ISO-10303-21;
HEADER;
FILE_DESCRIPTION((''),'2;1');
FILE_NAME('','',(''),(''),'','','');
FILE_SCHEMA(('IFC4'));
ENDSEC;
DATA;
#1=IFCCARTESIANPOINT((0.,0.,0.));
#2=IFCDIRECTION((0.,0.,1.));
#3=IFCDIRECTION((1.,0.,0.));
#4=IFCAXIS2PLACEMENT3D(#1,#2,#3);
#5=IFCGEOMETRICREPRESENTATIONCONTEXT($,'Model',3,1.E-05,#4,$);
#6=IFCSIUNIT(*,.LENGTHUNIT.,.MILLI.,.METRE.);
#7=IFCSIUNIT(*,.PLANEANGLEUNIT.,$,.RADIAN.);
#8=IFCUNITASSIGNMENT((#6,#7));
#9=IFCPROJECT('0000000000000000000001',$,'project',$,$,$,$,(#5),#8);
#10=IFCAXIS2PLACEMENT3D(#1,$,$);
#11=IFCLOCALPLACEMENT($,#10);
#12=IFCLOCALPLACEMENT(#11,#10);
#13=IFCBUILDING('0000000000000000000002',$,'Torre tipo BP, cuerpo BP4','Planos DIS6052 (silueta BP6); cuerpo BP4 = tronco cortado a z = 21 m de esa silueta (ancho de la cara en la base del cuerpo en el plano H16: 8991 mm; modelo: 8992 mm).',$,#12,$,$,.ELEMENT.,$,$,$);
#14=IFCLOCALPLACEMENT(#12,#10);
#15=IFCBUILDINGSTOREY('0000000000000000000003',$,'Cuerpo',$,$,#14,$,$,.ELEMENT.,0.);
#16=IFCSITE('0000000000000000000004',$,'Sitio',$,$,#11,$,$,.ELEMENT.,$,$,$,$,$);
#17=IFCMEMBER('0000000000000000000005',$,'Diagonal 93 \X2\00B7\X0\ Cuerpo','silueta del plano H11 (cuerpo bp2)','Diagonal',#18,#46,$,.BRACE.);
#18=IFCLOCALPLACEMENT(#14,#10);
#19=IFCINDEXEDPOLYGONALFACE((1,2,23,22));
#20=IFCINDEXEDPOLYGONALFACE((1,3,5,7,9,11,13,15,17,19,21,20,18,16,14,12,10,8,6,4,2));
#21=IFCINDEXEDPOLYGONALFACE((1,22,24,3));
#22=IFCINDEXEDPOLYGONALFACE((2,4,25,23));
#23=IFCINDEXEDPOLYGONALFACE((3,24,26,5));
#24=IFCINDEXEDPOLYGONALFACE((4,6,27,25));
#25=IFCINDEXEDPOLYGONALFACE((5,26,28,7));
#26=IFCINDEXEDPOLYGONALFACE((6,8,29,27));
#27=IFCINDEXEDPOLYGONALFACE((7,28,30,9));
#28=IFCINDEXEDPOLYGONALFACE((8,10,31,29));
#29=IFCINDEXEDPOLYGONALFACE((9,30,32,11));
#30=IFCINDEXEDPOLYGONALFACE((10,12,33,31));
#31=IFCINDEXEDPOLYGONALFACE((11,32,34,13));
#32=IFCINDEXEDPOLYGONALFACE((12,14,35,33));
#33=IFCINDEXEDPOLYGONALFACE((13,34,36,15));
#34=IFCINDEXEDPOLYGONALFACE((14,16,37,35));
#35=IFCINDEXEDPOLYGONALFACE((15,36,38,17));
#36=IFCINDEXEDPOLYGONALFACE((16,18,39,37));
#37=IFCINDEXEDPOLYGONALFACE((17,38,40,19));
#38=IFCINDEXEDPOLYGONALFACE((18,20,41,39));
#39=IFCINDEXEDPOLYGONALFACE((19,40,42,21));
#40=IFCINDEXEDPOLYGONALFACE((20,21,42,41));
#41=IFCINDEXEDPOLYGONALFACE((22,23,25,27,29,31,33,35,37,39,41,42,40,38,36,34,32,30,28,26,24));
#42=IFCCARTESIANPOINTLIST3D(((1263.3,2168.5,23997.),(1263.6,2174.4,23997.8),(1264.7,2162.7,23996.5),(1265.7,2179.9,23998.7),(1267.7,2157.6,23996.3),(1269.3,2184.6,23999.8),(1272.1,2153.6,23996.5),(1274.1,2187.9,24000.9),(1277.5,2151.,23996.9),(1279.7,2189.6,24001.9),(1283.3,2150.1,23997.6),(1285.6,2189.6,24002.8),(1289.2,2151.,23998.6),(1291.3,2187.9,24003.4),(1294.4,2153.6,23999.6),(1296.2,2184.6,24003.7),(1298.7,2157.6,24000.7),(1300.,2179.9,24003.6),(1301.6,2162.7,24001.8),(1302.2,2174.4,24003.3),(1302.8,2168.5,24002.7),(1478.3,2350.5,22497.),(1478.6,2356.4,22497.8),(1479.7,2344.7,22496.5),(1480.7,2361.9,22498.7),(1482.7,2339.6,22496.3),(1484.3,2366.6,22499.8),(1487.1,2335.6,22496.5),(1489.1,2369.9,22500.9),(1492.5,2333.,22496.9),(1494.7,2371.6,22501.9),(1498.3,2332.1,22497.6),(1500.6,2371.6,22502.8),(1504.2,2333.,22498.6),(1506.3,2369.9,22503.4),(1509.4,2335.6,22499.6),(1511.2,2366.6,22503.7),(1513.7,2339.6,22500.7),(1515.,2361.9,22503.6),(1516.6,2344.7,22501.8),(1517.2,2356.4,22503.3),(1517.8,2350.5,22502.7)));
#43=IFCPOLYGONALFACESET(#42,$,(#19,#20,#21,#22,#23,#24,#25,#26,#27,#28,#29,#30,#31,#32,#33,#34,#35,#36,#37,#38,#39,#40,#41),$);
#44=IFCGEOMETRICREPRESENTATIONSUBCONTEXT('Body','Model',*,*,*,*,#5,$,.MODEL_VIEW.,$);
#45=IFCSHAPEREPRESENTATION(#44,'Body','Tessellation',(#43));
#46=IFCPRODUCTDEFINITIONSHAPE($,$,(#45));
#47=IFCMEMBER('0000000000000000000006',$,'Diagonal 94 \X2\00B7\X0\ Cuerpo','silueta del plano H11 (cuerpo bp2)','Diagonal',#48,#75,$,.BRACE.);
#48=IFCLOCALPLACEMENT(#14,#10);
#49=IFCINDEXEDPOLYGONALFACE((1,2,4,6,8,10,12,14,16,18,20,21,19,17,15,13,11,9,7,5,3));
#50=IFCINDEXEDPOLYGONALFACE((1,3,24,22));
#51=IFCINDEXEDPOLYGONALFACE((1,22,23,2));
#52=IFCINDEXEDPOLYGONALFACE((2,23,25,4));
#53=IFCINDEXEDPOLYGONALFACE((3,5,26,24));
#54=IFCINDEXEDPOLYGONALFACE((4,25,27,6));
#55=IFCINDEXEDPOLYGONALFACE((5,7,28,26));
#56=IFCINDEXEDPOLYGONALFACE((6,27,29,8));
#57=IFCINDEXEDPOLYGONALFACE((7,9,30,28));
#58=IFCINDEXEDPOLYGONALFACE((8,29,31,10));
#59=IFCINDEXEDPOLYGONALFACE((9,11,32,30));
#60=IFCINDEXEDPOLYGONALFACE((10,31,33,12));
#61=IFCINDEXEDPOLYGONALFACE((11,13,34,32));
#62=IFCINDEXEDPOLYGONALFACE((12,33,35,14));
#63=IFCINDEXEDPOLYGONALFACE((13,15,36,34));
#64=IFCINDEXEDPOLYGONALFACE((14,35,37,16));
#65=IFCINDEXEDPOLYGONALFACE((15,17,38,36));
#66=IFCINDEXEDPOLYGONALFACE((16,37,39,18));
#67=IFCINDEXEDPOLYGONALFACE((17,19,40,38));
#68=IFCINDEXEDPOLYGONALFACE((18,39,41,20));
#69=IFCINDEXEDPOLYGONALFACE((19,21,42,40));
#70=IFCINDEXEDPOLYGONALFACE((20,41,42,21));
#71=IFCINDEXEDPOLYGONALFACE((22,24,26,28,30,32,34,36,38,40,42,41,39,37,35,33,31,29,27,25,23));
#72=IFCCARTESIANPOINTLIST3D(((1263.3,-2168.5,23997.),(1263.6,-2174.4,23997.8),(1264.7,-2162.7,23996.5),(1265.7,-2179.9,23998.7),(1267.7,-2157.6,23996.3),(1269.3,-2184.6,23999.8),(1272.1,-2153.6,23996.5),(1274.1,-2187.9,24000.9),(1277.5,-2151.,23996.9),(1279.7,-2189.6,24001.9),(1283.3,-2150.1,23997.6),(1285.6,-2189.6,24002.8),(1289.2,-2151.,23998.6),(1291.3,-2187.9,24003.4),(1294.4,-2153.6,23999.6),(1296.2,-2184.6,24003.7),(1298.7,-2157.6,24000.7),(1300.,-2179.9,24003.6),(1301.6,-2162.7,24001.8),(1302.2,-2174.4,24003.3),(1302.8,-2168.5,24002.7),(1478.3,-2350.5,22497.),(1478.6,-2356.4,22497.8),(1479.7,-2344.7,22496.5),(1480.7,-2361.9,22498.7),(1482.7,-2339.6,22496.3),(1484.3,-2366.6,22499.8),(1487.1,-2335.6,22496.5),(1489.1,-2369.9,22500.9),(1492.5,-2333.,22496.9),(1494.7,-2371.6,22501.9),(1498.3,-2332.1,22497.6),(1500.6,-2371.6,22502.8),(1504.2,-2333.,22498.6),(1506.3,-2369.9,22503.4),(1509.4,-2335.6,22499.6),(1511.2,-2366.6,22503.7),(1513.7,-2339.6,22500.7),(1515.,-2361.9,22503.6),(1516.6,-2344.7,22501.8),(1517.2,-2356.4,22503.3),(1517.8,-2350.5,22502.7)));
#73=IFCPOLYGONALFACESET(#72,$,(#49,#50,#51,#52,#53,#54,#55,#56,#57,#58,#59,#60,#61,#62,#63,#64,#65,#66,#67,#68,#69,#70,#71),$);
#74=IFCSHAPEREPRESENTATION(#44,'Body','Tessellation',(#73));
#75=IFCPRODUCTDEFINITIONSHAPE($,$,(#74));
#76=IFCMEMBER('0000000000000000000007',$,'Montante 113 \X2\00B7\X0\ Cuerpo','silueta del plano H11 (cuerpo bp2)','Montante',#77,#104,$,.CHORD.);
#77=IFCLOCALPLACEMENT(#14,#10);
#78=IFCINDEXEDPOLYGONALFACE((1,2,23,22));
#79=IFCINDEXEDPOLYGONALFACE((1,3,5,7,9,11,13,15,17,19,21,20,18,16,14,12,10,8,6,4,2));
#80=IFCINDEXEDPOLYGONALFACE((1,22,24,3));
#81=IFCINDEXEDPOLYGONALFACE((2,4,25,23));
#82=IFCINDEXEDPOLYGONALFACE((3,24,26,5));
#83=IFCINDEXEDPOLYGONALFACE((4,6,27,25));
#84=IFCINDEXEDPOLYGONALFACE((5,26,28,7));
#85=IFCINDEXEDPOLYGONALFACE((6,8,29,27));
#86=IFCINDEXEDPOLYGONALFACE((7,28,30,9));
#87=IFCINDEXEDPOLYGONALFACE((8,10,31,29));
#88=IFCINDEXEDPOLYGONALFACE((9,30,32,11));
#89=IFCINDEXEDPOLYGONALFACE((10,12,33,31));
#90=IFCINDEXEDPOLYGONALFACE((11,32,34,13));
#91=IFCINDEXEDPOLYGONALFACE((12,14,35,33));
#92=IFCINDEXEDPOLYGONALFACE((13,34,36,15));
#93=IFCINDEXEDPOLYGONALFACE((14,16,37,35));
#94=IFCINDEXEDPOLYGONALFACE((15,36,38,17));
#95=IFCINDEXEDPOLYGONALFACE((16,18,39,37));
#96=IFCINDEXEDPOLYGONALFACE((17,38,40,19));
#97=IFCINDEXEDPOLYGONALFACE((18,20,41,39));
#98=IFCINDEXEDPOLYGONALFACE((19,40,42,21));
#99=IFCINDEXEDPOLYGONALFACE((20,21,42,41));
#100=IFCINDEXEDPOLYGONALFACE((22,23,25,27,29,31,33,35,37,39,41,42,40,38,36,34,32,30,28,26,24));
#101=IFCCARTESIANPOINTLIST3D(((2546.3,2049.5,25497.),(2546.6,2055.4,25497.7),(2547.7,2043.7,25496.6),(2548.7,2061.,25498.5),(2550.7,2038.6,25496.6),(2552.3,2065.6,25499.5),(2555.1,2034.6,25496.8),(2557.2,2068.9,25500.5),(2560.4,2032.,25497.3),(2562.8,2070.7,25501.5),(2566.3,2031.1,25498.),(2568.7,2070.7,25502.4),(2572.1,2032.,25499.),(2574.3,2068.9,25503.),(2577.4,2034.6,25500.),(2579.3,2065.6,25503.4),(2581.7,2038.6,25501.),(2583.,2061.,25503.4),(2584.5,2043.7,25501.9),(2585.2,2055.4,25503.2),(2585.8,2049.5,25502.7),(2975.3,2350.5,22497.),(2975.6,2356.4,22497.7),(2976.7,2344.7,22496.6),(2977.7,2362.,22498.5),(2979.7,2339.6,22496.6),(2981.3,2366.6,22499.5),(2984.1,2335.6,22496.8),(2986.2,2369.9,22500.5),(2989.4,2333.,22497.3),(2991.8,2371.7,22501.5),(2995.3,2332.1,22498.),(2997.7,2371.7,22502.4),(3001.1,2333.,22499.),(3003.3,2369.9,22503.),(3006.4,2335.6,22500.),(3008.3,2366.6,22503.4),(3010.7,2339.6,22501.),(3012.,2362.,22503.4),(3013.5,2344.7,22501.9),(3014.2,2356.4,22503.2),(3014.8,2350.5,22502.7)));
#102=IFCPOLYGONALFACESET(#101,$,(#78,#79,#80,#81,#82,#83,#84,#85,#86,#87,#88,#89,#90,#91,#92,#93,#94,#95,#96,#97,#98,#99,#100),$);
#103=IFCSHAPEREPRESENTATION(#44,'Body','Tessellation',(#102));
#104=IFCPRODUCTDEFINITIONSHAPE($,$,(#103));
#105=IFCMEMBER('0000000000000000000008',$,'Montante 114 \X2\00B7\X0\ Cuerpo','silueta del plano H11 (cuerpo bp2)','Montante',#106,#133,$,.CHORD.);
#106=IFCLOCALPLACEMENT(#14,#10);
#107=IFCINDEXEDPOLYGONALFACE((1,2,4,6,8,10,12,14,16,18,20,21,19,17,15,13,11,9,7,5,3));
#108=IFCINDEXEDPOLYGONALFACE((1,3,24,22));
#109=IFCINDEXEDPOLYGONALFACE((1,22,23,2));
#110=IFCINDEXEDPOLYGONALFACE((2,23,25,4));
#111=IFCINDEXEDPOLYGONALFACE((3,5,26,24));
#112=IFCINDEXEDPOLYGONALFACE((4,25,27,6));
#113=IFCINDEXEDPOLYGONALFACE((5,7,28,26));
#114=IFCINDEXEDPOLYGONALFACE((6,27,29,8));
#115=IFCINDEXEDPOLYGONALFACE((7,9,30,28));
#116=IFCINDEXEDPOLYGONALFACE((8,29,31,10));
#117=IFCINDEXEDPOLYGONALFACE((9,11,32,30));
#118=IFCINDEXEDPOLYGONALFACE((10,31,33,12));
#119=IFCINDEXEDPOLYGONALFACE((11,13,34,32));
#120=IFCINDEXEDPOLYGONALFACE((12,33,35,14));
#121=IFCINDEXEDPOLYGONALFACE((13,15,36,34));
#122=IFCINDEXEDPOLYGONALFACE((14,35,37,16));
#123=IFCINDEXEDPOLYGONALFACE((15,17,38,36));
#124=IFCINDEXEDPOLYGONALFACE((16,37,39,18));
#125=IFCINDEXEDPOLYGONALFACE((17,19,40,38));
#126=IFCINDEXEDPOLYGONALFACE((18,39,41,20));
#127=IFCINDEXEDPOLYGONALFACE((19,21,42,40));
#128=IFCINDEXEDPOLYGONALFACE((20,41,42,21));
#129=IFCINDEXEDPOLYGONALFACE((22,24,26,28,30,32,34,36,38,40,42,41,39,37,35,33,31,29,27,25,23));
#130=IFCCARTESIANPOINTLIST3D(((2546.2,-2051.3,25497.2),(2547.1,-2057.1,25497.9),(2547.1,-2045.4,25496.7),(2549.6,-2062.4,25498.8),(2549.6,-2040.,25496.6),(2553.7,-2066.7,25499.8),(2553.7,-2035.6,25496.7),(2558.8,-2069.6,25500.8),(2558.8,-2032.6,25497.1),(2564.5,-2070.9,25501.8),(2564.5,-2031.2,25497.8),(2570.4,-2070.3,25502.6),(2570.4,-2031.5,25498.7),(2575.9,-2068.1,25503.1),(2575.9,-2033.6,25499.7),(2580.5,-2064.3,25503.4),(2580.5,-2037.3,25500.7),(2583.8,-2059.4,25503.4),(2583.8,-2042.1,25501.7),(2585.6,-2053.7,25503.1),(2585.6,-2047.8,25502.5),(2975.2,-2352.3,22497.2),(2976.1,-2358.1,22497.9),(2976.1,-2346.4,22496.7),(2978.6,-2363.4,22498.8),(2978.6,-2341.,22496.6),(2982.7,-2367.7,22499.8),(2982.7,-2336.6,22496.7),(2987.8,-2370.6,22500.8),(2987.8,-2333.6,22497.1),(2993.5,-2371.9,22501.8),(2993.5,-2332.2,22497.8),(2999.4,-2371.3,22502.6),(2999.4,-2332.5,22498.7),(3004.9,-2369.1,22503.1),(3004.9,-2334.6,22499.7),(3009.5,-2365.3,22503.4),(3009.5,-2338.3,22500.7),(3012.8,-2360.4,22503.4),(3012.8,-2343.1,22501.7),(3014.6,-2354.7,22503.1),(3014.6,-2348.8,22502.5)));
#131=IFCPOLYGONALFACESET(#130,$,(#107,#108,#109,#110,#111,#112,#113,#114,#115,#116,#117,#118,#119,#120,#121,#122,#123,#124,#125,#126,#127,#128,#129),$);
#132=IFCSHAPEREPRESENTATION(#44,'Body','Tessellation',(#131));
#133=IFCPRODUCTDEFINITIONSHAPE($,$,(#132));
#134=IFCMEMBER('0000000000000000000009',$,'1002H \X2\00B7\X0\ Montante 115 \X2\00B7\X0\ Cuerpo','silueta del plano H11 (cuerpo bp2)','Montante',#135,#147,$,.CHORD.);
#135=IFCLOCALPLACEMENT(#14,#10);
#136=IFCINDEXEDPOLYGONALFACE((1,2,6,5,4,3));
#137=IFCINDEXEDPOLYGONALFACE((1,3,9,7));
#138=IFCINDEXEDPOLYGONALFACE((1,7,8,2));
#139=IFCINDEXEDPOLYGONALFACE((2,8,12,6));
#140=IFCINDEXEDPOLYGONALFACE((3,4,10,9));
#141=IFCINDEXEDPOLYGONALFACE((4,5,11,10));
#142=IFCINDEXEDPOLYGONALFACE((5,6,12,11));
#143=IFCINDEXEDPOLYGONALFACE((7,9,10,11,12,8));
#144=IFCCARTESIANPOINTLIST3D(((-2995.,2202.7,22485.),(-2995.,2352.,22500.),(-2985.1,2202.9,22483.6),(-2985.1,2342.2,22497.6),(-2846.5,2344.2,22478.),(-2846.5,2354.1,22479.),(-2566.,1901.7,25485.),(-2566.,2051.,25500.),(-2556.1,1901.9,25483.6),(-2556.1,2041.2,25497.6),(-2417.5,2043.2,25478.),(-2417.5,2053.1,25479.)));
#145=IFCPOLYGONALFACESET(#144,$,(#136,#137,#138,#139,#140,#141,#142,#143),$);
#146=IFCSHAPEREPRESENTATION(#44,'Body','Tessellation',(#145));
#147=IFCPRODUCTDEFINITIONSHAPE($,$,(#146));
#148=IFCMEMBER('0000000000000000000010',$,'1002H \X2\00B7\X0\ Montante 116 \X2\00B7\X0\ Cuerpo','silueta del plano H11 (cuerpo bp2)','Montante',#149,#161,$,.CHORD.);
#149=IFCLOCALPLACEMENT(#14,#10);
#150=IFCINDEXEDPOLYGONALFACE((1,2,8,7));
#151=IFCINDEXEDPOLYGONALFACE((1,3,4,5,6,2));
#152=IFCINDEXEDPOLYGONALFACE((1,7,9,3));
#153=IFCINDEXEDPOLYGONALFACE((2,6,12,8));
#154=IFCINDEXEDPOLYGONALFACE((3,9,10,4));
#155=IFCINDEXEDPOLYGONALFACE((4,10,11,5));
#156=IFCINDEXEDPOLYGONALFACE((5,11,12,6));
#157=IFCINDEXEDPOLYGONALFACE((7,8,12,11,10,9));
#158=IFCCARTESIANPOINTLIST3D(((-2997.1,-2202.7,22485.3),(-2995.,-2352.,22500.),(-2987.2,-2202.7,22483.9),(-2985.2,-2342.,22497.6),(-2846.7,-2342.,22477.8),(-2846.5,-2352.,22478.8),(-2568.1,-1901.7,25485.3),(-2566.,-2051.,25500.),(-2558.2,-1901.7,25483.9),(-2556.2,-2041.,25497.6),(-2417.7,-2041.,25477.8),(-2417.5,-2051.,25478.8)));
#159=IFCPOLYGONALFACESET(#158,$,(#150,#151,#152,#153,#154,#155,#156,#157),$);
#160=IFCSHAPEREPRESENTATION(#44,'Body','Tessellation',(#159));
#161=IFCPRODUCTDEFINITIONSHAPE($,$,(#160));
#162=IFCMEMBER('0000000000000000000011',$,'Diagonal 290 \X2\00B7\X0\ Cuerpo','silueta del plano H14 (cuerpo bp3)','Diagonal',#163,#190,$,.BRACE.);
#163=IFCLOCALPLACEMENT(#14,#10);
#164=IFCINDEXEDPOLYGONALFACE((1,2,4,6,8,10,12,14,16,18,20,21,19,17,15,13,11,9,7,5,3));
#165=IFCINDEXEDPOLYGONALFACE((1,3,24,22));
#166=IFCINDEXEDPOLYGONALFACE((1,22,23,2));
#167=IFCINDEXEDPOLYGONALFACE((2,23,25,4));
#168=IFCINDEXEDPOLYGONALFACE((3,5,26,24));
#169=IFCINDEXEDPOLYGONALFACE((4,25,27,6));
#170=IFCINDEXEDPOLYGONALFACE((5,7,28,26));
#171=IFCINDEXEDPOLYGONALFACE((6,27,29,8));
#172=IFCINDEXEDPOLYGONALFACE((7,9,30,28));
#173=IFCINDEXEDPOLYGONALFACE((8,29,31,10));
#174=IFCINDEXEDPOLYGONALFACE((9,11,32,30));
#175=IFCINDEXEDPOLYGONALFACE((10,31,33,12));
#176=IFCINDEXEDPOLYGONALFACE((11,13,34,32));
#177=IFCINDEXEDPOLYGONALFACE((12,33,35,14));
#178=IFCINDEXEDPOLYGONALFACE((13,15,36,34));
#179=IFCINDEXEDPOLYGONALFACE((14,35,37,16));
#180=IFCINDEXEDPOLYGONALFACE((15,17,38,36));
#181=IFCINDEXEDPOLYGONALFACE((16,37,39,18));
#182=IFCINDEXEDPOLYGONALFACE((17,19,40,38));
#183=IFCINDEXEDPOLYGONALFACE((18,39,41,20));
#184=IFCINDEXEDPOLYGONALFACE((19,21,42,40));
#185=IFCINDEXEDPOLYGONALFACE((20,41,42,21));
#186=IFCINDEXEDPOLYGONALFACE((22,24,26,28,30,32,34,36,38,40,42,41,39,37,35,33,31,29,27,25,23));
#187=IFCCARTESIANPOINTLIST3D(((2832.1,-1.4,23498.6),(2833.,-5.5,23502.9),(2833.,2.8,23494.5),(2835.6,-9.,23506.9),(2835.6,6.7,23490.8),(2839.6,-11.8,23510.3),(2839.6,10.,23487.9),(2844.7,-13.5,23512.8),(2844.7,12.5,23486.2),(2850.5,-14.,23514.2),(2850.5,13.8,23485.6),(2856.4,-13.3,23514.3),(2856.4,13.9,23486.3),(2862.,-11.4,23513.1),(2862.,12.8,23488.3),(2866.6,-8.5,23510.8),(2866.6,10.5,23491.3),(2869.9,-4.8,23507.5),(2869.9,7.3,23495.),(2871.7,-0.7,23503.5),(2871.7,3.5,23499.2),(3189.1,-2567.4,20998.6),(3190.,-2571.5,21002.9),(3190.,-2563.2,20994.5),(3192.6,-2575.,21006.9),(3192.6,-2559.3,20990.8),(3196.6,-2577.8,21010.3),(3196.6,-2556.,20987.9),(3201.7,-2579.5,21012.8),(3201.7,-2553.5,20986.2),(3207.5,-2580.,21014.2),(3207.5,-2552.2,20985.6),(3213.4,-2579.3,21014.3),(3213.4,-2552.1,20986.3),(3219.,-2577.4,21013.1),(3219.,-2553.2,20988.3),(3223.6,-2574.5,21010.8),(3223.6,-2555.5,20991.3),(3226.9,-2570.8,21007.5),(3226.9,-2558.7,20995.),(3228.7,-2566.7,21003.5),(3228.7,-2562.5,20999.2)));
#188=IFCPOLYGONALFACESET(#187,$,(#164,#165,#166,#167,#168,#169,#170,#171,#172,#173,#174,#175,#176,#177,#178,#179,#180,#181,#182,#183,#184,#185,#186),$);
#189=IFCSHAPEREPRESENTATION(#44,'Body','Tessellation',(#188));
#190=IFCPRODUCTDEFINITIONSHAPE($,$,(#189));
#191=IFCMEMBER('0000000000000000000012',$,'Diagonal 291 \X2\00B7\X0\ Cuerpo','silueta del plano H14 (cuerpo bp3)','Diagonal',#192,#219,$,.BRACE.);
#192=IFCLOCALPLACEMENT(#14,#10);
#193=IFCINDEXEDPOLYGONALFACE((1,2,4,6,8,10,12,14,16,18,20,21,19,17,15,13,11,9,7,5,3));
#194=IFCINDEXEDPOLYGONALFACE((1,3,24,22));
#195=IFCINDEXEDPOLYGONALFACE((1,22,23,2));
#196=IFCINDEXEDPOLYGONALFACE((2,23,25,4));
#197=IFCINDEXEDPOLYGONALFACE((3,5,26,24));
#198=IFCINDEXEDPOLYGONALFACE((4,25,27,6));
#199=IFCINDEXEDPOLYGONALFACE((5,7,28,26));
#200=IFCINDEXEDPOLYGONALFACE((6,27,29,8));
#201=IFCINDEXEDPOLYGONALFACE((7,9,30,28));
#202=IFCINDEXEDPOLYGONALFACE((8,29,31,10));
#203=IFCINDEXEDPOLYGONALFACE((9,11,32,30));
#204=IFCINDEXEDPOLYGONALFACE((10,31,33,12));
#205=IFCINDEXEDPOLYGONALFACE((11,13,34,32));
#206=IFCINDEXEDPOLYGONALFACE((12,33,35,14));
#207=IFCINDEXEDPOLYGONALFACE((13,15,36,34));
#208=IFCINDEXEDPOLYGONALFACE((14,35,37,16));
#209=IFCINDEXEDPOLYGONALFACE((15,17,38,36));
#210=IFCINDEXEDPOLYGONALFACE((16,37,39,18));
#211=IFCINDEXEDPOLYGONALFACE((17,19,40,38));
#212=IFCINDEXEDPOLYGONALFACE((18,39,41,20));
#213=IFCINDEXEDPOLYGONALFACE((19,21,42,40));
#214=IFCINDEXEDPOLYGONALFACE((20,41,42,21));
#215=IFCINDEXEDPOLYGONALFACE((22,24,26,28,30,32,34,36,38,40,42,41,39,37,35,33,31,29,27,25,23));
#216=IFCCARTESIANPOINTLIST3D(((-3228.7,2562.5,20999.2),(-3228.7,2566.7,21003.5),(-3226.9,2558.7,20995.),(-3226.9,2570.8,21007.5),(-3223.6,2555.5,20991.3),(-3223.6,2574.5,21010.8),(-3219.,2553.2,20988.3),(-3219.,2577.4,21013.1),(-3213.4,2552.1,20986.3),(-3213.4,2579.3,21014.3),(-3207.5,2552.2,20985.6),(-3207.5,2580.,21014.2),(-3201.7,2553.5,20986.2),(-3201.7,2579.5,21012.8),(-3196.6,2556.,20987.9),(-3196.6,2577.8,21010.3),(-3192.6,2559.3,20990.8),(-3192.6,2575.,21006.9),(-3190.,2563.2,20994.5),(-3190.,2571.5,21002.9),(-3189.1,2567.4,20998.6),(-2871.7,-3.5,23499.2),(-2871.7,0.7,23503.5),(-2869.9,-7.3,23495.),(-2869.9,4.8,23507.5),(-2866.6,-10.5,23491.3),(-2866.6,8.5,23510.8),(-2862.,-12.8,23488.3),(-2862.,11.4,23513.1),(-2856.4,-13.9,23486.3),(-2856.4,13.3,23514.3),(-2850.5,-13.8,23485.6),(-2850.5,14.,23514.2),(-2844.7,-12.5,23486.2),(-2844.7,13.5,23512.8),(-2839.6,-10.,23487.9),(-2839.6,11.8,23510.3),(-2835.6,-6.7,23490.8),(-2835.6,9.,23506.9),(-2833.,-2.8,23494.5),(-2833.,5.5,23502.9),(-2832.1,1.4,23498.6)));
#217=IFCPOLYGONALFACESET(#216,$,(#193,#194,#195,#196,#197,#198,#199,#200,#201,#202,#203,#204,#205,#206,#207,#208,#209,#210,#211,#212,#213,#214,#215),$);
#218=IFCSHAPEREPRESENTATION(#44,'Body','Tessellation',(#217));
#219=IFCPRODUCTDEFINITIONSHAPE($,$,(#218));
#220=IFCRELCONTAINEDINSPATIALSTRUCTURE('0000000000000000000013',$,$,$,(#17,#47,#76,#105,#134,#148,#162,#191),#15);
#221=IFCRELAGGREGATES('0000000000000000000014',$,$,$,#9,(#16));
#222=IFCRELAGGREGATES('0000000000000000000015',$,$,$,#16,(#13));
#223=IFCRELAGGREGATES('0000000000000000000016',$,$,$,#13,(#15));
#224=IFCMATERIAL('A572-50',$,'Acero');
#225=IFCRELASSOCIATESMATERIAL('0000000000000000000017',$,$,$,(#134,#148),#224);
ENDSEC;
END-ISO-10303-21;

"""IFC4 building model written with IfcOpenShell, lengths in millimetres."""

from ifc_helpers import new_model, si_unit, frame, frame_2d, origin, origin_with_axes, place, context, subcontext, project, spatial, circle, l_section, extrude, material, element, save


model = new_model("IFC4")

# Units and contexts
model_context = context("Model", 3, precision=1e-05, world=origin_with_axes())
body_context = subcontext(model_context, "Body", "Model", "MODEL_VIEW")
ifc_project = project(units=[si_unit("LENGTHUNIT", "METRE", prefix="MILLI"), si_unit("PLANEANGLEUNIT", "RADIAN")], contexts=[model_context])

# Site, building, storey
site_placement = place(None, origin())
site = spatial("IfcSite", under=ifc_project, at=site_placement, Name="Sitio", CompositionType="ELEMENT")
building_placement = place(site_placement, origin())
building = spatial("IfcBuilding", under=site, at=building_placement, Name="Torre tipo BP, cuerpo BP4", Description="Planos DIS6052 (silueta BP6); cuerpo BP4 = tronco cortado a z = 21 m de esa silueta (ancho de la cara en la base del cuerpo en el plano H16: 8991 mm; modelo: 8992 mm).", CompositionType="ELEMENT")
storey_placement = place(building_placement, origin())
storey = spatial("IfcBuildingStorey", under=building, at=storey_placement, Name="Cuerpo", CompositionType="ELEMENT", Elevation=0.0)

# Members
for number, where, z_axis, x_axis, name in (
    (1, (1283.0, 2170.0, 24000.0), (0.140871, 0.119249, -0.98282), (0.016919, -0.992864, -0.118042), "Diagonal 93 · Cuerpo"),
    (2, (1283.0, -2170.0, 24000.0), (0.140871, -0.119249, -0.98282), (0.016919, 0.992864, -0.118042), "Diagonal 94 · Cuerpo"),
):
    element("IfcMember", number, at=place(storey_placement, frame(where, z_axis=z_axis, x_axis=x_axis)), inside=storey, Name=name, Description="silueta del plano H11 (cuerpo bp2)", ObjectType="Diagonal", PredefinedType="BRACE", context=body_context, shape_type="SweptSolid", body=[
        extrude(circle(Radius=20.0), None, (0.0, 0.0, 1.0), 1526.2),
    ])
for number, where, z_axis, x_axis, name in (
    (3, (2566.0, 2051.0, 25500.0), (0.140867, 0.098837, -0.985083), (0.013991, -0.995104, -0.097841), "Montante 113 · Cuerpo"),
    (4, (2566.0, -2051.0, 25500.0), (0.140867, -0.098837, -0.985083), (-0.990029, -0.014063, -0.140163), "Montante 114 · Cuerpo"),
):
    element("IfcMember", number, at=place(storey_placement, frame(where, z_axis=z_axis, x_axis=x_axis)), inside=storey, Name=name, Description="silueta del plano H11 (cuerpo bp2)", ObjectType="Montante", PredefinedType="CHORD", context=body_context, shape_type="SweptSolid", body=[
        extrude(circle(Radius=20.0), None, (0.0, 0.0, 1.0), 3045.4),
    ])
ifc_material = material(Name="A572-50", Category="Acero")
for number, where, z_axis, x_axis, name in (
    (5, (-2566.0, 2051.0, 25500.0), (-0.140867, 0.098837, -0.985083), (0.990029, 0.014063, -0.140163), "1002H · Montante 115 · Cuerpo"),
    (6, (-2566.0, -2051.0, 25500.0), (-0.140867, -0.098837, -0.985083), (-0.013991, 0.995104, -0.097841), "1002H · Montante 116 · Cuerpo"),
):
    element("IfcMember", number, at=place(storey_placement, frame(where, z_axis=z_axis, x_axis=x_axis)), inside=storey, material=ifc_material, Name=name, Description="silueta del plano H11 (cuerpo bp2)", ObjectType="Montante", PredefinedType="CHORD", context=body_context, shape_type="SweptSolid", body=[
        extrude(l_section(Depth=150.0, Width=150.0, Thickness=10.0, at=frame_2d((75.0, 75.0))), None, (0.0, 0.0, 1.0), 3045.4),
    ])
for number, where, z_axis, x_axis, name in (
    (7, (2852.0, 0.0, 23500.0), (0.09916, -0.712728, -0.694396), (-0.995072, -0.071024, -0.069197), "Diagonal 290 · Cuerpo"),
    (8, (-2852.0, 0.0, 23500.0), (-0.09916, 0.712728, -0.694396), (0.995072, 0.071024, -0.069197), "Diagonal 291 · Cuerpo"),
):
    element("IfcMember", number, at=place(storey_placement, frame(where, z_axis=z_axis, x_axis=x_axis)), inside=storey, Name=name, Description="silueta del plano H14 (cuerpo bp3)", ObjectType="Diagonal", PredefinedType="BRACE", context=body_context, shape_type="SweptSolid", body=[
        extrude(circle(Radius=20.0), None, (0.0, 0.0, 1.0), 3600.3),
    ])

save(model, "model.ifc")
